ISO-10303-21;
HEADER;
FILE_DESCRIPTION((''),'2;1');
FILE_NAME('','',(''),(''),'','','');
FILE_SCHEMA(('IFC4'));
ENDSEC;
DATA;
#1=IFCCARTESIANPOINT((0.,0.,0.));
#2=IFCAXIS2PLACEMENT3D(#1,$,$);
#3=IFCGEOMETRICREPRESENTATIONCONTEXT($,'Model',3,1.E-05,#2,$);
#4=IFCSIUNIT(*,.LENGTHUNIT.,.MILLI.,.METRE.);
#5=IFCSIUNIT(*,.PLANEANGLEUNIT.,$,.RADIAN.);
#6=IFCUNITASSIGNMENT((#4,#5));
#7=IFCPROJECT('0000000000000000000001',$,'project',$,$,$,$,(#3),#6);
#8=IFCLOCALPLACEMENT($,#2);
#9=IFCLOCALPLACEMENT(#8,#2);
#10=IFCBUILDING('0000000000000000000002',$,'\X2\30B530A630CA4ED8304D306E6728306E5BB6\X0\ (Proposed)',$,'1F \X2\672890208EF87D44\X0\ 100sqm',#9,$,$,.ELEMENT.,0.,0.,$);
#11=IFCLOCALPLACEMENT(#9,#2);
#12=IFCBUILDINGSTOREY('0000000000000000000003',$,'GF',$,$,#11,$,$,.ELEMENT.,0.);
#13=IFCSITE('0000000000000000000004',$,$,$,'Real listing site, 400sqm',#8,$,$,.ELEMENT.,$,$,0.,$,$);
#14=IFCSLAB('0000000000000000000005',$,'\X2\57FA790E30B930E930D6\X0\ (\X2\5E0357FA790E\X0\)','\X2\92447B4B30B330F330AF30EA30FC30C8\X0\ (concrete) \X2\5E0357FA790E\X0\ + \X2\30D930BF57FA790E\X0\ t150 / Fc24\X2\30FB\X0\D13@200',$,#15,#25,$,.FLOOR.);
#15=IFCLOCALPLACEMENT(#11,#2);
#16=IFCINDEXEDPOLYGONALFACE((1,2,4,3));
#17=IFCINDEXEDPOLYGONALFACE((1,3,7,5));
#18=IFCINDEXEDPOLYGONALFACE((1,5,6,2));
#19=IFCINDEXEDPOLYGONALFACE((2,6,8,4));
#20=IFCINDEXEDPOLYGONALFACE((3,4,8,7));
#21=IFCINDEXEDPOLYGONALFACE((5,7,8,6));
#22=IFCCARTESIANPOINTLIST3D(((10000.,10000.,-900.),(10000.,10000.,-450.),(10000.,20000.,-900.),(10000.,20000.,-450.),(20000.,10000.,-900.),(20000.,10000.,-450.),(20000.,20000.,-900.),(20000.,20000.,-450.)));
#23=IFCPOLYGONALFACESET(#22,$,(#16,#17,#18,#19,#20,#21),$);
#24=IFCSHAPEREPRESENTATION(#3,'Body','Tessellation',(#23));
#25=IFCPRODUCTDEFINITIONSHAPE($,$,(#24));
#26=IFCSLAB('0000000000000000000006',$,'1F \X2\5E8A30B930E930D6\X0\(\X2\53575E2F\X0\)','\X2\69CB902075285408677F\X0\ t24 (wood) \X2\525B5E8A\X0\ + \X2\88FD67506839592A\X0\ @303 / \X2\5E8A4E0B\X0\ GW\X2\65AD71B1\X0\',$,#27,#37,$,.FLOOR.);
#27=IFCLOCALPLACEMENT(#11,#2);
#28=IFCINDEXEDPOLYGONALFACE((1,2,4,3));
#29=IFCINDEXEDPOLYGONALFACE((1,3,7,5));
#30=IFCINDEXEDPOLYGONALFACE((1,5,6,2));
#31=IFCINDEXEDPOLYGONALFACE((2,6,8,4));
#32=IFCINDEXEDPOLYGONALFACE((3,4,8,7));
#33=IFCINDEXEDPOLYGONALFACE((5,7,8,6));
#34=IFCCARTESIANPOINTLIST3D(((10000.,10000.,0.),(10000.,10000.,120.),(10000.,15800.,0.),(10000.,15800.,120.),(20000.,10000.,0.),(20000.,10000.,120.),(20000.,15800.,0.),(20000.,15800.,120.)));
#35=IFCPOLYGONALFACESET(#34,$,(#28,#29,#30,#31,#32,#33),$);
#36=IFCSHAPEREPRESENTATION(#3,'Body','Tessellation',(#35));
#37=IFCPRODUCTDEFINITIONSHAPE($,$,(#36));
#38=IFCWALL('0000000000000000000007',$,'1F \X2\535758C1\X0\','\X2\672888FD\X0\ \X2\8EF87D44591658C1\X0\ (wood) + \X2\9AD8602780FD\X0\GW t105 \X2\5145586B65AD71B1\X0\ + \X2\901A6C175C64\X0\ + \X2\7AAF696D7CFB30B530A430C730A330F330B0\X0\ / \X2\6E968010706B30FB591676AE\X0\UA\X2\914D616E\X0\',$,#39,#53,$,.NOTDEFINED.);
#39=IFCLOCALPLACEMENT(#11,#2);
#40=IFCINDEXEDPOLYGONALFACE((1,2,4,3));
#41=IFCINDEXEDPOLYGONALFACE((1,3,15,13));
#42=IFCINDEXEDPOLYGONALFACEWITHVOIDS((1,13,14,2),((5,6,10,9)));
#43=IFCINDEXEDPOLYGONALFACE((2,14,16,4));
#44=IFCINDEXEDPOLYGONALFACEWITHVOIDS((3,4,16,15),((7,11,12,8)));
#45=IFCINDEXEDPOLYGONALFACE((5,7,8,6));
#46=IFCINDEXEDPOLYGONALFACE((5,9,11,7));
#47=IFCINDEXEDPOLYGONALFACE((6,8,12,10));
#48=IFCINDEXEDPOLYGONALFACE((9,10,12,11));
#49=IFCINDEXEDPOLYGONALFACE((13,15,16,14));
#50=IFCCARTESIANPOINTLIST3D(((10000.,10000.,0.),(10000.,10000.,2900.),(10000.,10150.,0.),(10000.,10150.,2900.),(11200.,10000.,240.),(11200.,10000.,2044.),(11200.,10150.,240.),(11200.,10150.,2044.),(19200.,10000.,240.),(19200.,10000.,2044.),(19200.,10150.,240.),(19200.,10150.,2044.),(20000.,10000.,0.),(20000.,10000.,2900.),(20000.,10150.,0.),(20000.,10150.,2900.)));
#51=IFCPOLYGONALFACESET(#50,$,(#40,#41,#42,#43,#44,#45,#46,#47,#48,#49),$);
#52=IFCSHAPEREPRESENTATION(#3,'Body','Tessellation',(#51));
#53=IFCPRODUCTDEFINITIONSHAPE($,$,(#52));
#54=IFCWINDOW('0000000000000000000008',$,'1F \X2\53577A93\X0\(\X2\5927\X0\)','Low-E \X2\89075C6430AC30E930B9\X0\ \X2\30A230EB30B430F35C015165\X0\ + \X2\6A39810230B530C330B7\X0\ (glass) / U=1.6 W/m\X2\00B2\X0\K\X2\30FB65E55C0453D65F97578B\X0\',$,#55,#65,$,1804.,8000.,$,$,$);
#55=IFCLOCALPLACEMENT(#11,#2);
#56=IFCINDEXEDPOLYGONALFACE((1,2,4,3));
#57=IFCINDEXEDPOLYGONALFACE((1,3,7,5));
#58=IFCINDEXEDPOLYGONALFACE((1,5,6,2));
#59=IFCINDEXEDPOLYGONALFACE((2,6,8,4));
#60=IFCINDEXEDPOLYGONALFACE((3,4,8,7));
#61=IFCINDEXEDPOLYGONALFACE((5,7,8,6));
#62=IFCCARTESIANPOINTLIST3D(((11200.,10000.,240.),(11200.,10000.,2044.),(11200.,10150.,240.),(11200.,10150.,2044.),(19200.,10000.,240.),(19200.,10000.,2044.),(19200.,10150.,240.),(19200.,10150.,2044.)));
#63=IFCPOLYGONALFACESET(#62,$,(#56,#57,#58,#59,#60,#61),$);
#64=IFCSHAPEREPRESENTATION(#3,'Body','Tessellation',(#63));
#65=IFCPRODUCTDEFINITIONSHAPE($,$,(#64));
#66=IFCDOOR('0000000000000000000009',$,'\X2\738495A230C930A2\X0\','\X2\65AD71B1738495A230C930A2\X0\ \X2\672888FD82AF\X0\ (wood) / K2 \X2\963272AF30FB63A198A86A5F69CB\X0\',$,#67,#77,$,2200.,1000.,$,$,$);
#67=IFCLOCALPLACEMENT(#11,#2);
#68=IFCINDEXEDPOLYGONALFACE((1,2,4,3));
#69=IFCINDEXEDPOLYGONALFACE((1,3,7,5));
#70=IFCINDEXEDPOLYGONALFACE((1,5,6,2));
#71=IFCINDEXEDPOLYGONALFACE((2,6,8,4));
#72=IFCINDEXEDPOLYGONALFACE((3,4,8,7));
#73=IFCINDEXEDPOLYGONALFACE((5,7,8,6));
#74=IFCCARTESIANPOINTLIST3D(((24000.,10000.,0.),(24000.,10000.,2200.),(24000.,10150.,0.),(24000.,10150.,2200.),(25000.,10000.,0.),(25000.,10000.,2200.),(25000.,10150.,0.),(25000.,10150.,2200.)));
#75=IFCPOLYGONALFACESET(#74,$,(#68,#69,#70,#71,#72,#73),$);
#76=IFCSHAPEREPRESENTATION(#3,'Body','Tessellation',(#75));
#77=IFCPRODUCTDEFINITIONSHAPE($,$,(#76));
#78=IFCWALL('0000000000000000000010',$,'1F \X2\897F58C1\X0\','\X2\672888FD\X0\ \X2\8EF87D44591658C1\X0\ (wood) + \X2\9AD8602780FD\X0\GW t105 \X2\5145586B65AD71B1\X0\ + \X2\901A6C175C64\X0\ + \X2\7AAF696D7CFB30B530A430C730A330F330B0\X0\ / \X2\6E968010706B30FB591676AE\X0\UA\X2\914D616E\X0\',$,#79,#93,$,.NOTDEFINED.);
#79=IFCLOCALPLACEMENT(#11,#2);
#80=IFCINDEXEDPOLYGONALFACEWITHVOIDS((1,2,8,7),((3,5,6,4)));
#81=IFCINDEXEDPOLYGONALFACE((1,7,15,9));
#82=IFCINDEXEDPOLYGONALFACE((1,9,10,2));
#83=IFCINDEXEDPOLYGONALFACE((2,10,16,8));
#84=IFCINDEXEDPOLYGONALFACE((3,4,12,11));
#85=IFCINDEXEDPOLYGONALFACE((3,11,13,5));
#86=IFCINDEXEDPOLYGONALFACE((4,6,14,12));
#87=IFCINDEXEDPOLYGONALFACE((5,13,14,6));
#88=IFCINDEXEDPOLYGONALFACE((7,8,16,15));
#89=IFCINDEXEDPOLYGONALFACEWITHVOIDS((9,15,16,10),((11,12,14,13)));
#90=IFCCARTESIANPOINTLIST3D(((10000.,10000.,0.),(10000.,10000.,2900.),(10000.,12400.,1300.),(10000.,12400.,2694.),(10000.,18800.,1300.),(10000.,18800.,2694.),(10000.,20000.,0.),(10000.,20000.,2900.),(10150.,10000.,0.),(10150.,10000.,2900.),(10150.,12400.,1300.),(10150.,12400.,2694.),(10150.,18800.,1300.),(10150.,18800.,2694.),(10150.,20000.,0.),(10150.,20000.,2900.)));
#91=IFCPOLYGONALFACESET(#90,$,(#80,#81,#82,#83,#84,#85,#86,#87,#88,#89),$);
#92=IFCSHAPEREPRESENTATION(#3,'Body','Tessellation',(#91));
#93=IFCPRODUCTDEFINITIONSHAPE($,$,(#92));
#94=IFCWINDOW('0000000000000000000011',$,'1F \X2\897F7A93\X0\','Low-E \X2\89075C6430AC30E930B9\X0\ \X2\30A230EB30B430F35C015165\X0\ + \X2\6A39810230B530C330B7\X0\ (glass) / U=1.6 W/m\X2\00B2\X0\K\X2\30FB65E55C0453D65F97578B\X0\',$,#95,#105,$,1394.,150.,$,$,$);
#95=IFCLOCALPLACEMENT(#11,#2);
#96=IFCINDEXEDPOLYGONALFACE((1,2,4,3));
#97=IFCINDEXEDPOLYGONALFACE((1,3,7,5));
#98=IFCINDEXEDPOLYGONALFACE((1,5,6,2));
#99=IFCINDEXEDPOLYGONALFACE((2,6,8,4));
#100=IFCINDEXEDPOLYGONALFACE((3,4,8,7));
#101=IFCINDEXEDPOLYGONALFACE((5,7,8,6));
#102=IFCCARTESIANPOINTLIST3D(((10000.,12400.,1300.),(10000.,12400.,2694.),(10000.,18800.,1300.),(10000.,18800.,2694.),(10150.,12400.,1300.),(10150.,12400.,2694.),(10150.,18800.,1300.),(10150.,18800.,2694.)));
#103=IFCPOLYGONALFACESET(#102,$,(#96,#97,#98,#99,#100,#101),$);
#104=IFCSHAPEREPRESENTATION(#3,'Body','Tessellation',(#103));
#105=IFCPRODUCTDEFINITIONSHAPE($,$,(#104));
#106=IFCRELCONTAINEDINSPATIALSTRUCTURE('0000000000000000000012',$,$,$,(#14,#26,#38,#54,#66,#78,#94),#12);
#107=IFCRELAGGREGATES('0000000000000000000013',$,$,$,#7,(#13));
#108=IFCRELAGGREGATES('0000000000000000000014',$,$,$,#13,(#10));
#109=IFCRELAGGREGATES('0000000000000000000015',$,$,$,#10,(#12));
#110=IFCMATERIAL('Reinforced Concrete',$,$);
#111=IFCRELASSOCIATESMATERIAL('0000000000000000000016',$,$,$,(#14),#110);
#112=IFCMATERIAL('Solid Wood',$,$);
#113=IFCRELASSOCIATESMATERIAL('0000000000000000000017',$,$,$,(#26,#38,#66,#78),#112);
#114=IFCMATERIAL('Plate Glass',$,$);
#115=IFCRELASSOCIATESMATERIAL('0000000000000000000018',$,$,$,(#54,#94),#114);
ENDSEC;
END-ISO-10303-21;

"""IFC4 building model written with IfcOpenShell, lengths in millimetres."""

from ifc_helpers import new_model, si_unit, frame, frame_2d, origin, place, context, project, spatial, rectangle, extrude, material, element, fill, save


model = new_model("IFC4")

# Units and contexts
model_context = context("Model", 3, precision=1e-05, world=origin())
ifc_project = project(units=[si_unit("LENGTHUNIT", "METRE", prefix="MILLI"), si_unit("PLANEANGLEUNIT", "RADIAN")], contexts=[model_context])

# Site, building, storey
site_placement = place(None, origin())
site = spatial("IfcSite", under=ifc_project, at=site_placement, ObjectType="Real listing site, 400sqm", CompositionType="ELEMENT", RefElevation=0.0)
building_placement = place(site_placement, origin())
building = spatial("IfcBuilding", under=site, at=building_placement, Name="サウナ付きの木の家 (Proposed)", ObjectType="1F 木造軸組 100sqm", CompositionType="ELEMENT", ElevationOfRefHeight=0.0, ElevationOfTerrain=0.0)
storey_placement = place(building_placement, origin())
storey = spatial("IfcBuildingStorey", under=building, at=storey_placement, Name="GF", CompositionType="ELEMENT", Elevation=0.0)

# Slabs
ifc_material_1 = material(Name="Reinforced Concrete")
slab_1_placement = place(storey_placement, frame((5000.0, 5000.0, -450.0)))
element("IfcSlab", 1, at=slab_1_placement, inside=storey, material=ifc_material_1, Name="基礎スラブ (布基礎)", Description="鉄筋コンクリート (concrete) 布基礎 + ベタ基礎 t150 / Fc24・D13@200", PredefinedType="FLOOR", context=model_context, shape_type="SweptSolid", body=[
    extrude(rectangle(XDim=10000.0, YDim=10000.0, at=frame_2d((5000.0, 5000.0))), frame((5000.0, 5000.0, -450.0)), (0.0, 0.0, 1.0), 450.0),
])
ifc_material_2 = material(Name="Solid Wood")
slab_2_placement = place(storey_placement, frame((5000.0, 5000.0, 0.0)))
element("IfcSlab", 2, at=slab_2_placement, inside=storey, material=ifc_material_2, Name="1F 床スラブ(南帯)", Description="構造用合板 t24 (wood) 剛床 + 製材根太 @303 / 床下 GW断熱", PredefinedType="FLOOR", context=model_context, shape_type="SweptSolid", body=[
    extrude(rectangle(XDim=10000.0, YDim=5800.0, at=frame_2d((5000.0, 2900.0))), frame((5000.0, 5000.0, 0.0)), (0.0, 0.0, 1.0), 120.0),
])

# Wall, openings, window, door
wall_1_placement = place(storey_placement, frame((5000.0, 5000.0, 0.0)))
wall_1 = element("IfcWall", 3, at=wall_1_placement, inside=storey, material=ifc_material_2, Name="1F 南壁", Description="木製 軸組外壁 (wood) + 高性能GW t105 充填断熱 + 通気層 + 窯業系サイディング / 準耐火・外皮UA配慮", PredefinedType="NOTDEFINED", context=model_context, shape_type="SweptSolid", body=[
    extrude(rectangle(XDim=10000.0, YDim=150.0, at=frame_2d((5000.0, 75.0))), frame((5000.0, 5000.0, 0.0)), (0.0, 0.0, 1.0), 2900.0),
])
opening_1_placement = place(storey_placement, frame((5600.0, 5000.0, 120.0)))
opening_1 = element("IfcOpeningElement", 4, at=opening_1_placement, cuts=wall_1, PredefinedType="NOTDEFINED", context=model_context, shape_type="SweptSolid", body=[
    extrude(rectangle(XDim=8000.0, YDim=150.0, at=frame_2d((4000.0, 75.0))), frame((5600.0, 5000.0, 120.0)), (0.0, 0.0, 1.0), 1804.0),
])
opening_2_placement = place(storey_placement, frame((12000.0, 5000.0, 0.0)))
opening_2 = element("IfcOpeningElement", 5, at=opening_2_placement, cuts=wall_1, PredefinedType="NOTDEFINED", context=model_context, shape_type="SweptSolid", body=[
    extrude(rectangle(XDim=1000.0, YDim=150.0, at=frame_2d((500.0, 75.0))), frame((12000.0, 5000.0, 0.0)), (0.0, 0.0, 1.0), 2200.0),
])
ifc_material_3 = material(Name="Plate Glass")
window_1_placement = place(storey_placement, frame((5600.0, 5000.0, 120.0)))
window_1 = element("IfcWindow", 6, at=window_1_placement, inside=storey, material=ifc_material_3, Name="1F 南窓(大)", Description="Low-E 複層ガラス アルゴン封入 + 樹脂サッシ (glass) / U=1.6 W/m²K・日射取得型", OverallHeight=1804.0, OverallWidth=8000.0, context=model_context, shape_type="SweptSolid", body=[
    extrude(rectangle(XDim=8000.0, YDim=150.0, at=frame_2d((4000.0, 75.0))), frame((5600.0, 5000.0, 120.0)), (0.0, 0.0, 1.0), 1804.0),
])
fill(opening_1, window_1)
door_placement = place(storey_placement, frame((12000.0, 5000.0, 0.0)))
door = element("IfcDoor", 7, at=door_placement, inside=storey, material=ifc_material_2, Name="玄関ドア", Description="断熱玄関ドア 木製芯 (wood) / K2 防犯・採風機構", OverallHeight=2200.0, OverallWidth=1000.0, context=model_context, shape_type="SweptSolid", body=[
    extrude(rectangle(XDim=1000.0, YDim=150.0, at=frame_2d((500.0, 75.0))), frame((12000.0, 5000.0, 0.0)), (0.0, 0.0, 1.0), 2200.0),
])
fill(opening_2, door)

# Wall, opening, window
wall_2_placement = place(storey_placement, frame((5000.0, 5000.0, 0.0)))
wall_2 = element("IfcWall", 8, at=wall_2_placement, inside=storey, material=ifc_material_2, Name="1F 西壁", Description="木製 軸組外壁 (wood) + 高性能GW t105 充填断熱 + 通気層 + 窯業系サイディング / 準耐火・外皮UA配慮", PredefinedType="NOTDEFINED", context=model_context, shape_type="SweptSolid", body=[
    extrude(rectangle(XDim=150.0, YDim=10000.0, at=frame_2d((75.0, 5000.0))), frame((5000.0, 5000.0, 0.0)), (0.0, 0.0, 1.0), 2900.0),
])
opening_3_placement = place(storey_placement, frame((5000.0, 6200.0, 650.0)))
opening_3 = element("IfcOpeningElement", 9, at=opening_3_placement, cuts=wall_2, PredefinedType="NOTDEFINED", context=model_context, shape_type="SweptSolid", body=[
    extrude(rectangle(XDim=150.0, YDim=6400.0, at=frame_2d((75.0, 3200.0))), frame((5000.0, 6200.0, 650.0)), (0.0, 0.0, 1.0), 1394.0),
])
window_2_placement = place(storey_placement, frame((5000.0, 6200.0, 650.0)))
window_2 = element("IfcWindow", 10, at=window_2_placement, inside=storey, material=ifc_material_3, Name="1F 西窓", Description="Low-E 複層ガラス アルゴン封入 + 樹脂サッシ (glass) / U=1.6 W/m²K・日射取得型", OverallHeight=1394.0, OverallWidth=150.0, context=model_context, shape_type="SweptSolid", body=[
    extrude(rectangle(XDim=150.0, YDim=6400.0, at=frame_2d((75.0, 3200.0))), frame((5000.0, 6200.0, 650.0)), (0.0, 0.0, 1.0), 1394.0),
])
fill(opening_3, window_2)

save(model, "model.ifc")
